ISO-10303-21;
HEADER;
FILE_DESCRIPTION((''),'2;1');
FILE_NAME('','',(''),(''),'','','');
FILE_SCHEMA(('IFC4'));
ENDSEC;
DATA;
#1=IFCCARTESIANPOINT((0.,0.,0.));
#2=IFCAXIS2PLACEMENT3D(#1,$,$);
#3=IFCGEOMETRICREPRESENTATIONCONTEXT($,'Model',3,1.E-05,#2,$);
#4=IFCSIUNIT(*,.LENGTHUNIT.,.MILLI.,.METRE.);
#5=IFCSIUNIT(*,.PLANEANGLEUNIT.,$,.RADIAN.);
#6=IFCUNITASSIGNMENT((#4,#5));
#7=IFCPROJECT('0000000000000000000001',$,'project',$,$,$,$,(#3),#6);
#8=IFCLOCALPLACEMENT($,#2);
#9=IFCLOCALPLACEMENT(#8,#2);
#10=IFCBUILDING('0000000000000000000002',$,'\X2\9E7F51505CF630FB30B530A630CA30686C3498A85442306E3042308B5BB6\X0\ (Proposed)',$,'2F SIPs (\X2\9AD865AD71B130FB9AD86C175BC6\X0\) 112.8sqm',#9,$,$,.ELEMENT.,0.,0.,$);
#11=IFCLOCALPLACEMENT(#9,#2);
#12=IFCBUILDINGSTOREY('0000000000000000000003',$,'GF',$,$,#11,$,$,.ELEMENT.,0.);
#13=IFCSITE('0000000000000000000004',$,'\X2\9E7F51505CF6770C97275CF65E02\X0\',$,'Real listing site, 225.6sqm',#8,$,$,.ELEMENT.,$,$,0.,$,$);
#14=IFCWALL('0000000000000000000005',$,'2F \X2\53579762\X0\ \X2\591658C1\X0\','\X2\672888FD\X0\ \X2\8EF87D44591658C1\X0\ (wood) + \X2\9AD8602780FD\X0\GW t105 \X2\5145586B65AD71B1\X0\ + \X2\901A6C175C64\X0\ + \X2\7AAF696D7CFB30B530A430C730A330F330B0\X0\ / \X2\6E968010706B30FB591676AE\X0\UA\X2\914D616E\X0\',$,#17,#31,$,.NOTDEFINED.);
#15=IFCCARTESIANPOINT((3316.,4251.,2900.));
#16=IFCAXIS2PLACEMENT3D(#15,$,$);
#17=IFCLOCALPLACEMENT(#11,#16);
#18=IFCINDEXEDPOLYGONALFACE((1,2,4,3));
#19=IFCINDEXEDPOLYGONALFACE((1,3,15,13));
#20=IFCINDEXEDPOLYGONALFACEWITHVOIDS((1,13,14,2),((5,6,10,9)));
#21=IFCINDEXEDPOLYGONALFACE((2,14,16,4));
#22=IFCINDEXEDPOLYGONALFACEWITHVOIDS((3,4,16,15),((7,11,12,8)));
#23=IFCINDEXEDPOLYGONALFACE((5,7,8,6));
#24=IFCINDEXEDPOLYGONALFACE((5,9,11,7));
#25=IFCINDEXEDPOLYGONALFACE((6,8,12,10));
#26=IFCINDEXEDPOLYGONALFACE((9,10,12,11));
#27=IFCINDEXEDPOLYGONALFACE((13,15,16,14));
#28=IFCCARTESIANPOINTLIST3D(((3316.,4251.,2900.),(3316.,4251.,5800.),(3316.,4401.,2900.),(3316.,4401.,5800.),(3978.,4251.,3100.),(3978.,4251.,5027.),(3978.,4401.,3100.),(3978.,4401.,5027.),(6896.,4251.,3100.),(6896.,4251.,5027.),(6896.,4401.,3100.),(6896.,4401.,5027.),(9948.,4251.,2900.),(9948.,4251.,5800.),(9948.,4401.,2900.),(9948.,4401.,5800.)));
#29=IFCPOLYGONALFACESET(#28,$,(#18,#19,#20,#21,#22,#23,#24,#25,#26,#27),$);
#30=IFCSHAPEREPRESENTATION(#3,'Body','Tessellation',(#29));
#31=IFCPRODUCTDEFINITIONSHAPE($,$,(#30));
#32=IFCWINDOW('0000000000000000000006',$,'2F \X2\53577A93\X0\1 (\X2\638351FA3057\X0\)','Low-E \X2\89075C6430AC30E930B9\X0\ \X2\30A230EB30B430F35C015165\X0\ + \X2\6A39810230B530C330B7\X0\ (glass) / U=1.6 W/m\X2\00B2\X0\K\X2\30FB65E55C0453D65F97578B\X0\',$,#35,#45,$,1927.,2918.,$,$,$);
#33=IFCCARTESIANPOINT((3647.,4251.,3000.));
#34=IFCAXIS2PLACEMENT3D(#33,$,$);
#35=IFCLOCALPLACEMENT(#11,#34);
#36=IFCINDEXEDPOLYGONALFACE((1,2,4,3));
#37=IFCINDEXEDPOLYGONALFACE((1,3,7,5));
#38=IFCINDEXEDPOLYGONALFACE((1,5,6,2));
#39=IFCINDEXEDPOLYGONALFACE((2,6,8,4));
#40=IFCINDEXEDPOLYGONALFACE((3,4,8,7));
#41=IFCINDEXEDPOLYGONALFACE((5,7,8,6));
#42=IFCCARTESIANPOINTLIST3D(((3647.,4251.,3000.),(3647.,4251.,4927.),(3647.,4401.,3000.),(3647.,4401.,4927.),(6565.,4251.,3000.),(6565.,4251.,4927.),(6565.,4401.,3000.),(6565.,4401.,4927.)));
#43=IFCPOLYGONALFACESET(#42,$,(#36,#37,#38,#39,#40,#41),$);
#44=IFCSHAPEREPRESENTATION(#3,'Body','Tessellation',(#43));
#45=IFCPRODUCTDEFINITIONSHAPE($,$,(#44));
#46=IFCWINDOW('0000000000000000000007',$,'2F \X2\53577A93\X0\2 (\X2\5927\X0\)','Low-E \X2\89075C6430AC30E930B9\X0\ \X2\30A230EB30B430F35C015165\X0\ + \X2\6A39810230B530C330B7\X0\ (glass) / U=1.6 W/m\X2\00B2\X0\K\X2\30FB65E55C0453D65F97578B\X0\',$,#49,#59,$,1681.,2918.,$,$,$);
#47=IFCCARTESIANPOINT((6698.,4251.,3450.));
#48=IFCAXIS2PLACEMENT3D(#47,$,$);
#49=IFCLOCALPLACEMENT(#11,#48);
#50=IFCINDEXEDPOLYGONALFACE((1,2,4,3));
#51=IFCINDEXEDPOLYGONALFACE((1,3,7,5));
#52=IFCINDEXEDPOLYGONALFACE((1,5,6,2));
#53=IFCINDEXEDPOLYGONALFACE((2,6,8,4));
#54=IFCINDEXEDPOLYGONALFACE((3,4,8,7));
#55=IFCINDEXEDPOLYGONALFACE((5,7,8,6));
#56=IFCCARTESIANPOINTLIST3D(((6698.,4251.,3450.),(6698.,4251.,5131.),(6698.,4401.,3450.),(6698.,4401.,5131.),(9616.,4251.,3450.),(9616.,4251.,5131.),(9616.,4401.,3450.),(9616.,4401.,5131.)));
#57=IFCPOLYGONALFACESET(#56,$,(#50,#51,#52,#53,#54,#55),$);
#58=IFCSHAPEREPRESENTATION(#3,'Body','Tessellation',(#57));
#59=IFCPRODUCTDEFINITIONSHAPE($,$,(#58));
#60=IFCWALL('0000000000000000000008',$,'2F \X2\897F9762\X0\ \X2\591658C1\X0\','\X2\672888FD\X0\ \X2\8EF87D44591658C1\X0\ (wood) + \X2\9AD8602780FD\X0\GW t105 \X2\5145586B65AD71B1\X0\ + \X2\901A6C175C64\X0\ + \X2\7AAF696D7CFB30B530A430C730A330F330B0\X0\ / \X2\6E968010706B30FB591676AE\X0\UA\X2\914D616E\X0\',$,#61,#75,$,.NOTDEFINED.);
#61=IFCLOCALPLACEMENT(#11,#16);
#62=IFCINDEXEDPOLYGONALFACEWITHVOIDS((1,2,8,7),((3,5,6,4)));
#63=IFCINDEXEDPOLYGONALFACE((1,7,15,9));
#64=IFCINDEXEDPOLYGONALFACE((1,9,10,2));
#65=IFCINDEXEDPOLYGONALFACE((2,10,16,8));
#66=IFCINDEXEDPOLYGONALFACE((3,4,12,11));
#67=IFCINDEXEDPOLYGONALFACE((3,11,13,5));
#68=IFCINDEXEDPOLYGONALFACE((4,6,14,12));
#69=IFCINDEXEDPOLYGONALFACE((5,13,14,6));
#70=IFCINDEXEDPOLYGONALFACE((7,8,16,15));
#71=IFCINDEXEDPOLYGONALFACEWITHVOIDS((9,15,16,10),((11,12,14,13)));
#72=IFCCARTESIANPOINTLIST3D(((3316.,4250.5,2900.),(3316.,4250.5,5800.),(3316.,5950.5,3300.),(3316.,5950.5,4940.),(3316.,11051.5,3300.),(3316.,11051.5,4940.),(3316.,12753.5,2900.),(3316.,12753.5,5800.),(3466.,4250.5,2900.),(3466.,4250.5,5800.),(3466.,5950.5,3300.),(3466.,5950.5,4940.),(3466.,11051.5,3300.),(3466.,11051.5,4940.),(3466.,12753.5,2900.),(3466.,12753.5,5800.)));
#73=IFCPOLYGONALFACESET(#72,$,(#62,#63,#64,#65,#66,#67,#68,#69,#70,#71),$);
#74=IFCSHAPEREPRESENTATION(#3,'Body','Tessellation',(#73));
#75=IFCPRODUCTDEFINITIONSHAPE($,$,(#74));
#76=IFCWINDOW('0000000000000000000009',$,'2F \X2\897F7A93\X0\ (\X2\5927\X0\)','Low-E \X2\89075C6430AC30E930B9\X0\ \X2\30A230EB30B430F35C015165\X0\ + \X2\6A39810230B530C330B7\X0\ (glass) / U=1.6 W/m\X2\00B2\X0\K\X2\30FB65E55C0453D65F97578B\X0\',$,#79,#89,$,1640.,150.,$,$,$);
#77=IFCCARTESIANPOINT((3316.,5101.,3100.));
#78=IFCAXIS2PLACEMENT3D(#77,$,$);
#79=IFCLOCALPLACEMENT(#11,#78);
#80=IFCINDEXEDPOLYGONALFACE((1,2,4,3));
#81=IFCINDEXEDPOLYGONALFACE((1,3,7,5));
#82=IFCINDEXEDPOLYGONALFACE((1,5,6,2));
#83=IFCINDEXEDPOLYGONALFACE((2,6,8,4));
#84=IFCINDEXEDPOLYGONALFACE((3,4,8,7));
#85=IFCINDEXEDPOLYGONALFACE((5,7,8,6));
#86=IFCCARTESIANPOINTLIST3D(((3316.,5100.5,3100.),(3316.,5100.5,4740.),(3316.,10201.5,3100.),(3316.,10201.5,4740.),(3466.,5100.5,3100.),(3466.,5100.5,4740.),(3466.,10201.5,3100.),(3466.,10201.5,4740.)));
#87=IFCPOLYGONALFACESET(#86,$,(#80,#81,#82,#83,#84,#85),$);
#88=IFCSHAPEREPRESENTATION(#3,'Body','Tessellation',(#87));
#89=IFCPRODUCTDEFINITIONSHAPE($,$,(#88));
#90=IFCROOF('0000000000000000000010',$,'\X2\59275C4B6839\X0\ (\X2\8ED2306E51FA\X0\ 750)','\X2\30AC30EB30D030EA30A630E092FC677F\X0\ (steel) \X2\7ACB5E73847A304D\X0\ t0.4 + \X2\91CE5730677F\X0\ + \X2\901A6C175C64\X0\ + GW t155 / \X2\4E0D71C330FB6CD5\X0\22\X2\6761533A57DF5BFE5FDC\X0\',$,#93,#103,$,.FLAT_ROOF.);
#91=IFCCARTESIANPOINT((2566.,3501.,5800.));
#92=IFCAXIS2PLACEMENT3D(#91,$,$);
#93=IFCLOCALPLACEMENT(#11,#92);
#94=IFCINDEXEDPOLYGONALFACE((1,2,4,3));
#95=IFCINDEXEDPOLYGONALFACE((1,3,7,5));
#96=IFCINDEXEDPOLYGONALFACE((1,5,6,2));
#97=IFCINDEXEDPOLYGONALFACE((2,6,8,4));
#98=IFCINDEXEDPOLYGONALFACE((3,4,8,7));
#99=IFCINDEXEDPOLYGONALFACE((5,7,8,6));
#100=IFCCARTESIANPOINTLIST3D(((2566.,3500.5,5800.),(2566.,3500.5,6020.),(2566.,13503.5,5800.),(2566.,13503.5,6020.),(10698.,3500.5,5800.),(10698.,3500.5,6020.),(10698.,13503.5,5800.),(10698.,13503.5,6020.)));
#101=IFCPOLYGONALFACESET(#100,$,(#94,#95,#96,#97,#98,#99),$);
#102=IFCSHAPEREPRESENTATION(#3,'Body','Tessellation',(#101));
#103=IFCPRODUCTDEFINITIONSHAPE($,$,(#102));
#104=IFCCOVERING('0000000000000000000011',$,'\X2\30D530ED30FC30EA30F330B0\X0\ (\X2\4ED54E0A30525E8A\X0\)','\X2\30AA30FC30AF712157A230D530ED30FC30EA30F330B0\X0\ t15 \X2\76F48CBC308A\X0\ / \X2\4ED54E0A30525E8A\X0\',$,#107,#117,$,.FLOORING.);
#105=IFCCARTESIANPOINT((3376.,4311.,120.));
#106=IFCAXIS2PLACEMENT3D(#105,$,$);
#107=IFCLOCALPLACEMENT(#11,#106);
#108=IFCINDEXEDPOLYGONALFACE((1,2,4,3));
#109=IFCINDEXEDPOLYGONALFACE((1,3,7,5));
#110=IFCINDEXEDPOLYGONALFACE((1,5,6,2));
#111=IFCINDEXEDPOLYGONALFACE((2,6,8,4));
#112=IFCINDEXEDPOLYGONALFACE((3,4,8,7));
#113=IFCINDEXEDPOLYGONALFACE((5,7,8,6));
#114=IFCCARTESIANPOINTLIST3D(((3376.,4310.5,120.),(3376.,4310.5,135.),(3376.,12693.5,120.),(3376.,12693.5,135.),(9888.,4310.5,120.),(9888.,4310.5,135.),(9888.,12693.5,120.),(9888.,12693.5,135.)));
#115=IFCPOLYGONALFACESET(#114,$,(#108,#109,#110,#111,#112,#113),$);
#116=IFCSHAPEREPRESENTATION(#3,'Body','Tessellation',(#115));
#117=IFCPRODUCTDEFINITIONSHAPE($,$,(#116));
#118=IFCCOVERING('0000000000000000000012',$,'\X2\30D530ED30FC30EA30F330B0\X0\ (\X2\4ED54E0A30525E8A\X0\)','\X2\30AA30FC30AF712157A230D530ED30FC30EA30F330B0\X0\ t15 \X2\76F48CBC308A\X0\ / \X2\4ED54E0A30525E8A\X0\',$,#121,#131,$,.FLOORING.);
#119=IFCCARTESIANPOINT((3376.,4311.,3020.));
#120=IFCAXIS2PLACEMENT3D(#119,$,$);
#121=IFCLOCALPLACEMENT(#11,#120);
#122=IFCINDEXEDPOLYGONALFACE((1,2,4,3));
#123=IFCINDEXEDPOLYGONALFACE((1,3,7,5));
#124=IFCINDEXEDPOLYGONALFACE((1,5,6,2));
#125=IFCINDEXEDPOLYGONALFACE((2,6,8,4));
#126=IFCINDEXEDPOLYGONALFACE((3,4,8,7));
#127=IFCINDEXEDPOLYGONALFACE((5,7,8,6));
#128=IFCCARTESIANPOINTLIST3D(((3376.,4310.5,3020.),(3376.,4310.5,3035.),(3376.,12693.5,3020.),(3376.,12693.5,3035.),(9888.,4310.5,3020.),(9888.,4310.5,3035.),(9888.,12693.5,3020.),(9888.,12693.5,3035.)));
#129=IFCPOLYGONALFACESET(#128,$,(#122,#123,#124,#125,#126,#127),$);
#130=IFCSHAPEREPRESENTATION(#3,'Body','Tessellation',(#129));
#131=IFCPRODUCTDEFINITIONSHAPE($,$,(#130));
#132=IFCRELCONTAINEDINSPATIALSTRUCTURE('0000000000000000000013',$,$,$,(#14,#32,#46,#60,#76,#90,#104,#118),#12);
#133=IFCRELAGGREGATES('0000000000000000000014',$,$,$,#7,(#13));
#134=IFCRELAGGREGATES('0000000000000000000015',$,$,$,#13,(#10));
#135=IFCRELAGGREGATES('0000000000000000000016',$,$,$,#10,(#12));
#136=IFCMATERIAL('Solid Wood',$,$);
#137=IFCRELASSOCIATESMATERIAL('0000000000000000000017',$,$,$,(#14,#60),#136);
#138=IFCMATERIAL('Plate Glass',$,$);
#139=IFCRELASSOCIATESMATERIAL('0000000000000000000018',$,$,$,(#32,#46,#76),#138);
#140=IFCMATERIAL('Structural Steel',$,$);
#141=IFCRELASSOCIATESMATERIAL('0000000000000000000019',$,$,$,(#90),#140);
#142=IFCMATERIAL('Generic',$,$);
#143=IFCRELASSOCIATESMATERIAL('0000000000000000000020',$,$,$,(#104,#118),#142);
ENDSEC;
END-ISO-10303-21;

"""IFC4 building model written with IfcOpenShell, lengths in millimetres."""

from ifc_helpers import new_model, si_unit, frame, frame_2d, origin, place, context, project, spatial, rectangle, extrude, material, element, fill, save


model = new_model("IFC4")

# Units and contexts
model_context = context("Model", 3, precision=1e-05, world=origin())
ifc_project = project(units=[si_unit("LENGTHUNIT", "METRE", prefix="MILLI"), si_unit("PLANEANGLEUNIT", "RADIAN")], contexts=[model_context])

# Site, building, storey
site_placement = place(None, origin())
site = spatial("IfcSite", under=ifc_project, at=site_placement, Name="鹿児島県霧島市", ObjectType="Real listing site, 225.6sqm", CompositionType="ELEMENT", RefElevation=0.0)
building_placement = place(site_placement, origin())
building = spatial("IfcBuilding", under=site, at=building_placement, Name="鹿児島・サウナと水風呂のある家 (Proposed)", ObjectType="2F SIPs (高断熱・高気密) 112.8sqm", CompositionType="ELEMENT", ElevationOfRefHeight=0.0, ElevationOfTerrain=0.0)
storey_placement = place(building_placement, origin())
storey = spatial("IfcBuildingStorey", under=building, at=storey_placement, Name="GF", CompositionType="ELEMENT", Elevation=0.0)

# Shared definitions
ifc_material_1 = material(Name="Solid Wood")

# Shared definitions
ifc_material_2 = material(Name="Plate Glass")

# Wall, openings, windows
wall_1_placement = place(storey_placement, frame((3316.0, 4251.0, 2900.0)))
wall_1 = element("IfcWall", 1, at=wall_1_placement, inside=storey, material=ifc_material_1, Name="2F 南面 外壁", Description="木製 軸組外壁 (wood) + 高性能GW t105 充填断熱 + 通気層 + 窯業系サイディング / 準耐火・外皮UA配慮", PredefinedType="NOTDEFINED", context=model_context, shape_type="SweptSolid", body=[
    extrude(rectangle(XDim=6632.0, YDim=150.0, at=frame_2d((3316.0, 75.0))), frame((3316.0, 4251.0, 2900.0)), (0.0, 0.0, 1.0), 2900.0),
])
opening_1_placement = place(storey_placement, frame((3647.0, 4251.0, 3000.0)))
opening_1 = element("IfcOpeningElement", 2, at=opening_1_placement, cuts=wall_1, PredefinedType="NOTDEFINED", context=model_context, shape_type="SweptSolid", body=[
    extrude(rectangle(XDim=2918.0, YDim=150.0, at=frame_2d((1459.0, 75.0))), frame((3647.0, 4251.0, 3000.0)), (0.0, 0.0, 1.0), 1927.0),
])
opening_2_placement = place(storey_placement, frame((6698.0, 4251.0, 3450.0)))
opening_2 = element("IfcOpeningElement", 3, at=opening_2_placement, cuts=wall_1, PredefinedType="NOTDEFINED", context=model_context, shape_type="SweptSolid", body=[
    extrude(rectangle(XDim=2918.0, YDim=150.0, at=frame_2d((1459.0, 75.0))), frame((6698.0, 4251.0, 3450.0)), (0.0, 0.0, 1.0), 1681.0),
])
window_1_placement = place(storey_placement, frame((3647.0, 4251.0, 3000.0)))
window_1 = element("IfcWindow", 4, at=window_1_placement, inside=storey, material=ifc_material_2, Name="2F 南窓1 (掃出し)", Description="Low-E 複層ガラス アルゴン封入 + 樹脂サッシ (glass) / U=1.6 W/m²K・日射取得型", OverallHeight=1927.0, OverallWidth=2918.0, context=model_context, shape_type="SweptSolid", body=[
    extrude(rectangle(XDim=2918.0, YDim=150.0, at=frame_2d((1459.0, 75.0))), frame((3647.0, 4251.0, 3000.0)), (0.0, 0.0, 1.0), 1927.0),
])
fill(opening_1, window_1)
window_2_placement = place(storey_placement, frame((6698.0, 4251.0, 3450.0)))
window_2 = element("IfcWindow", 5, at=window_2_placement, inside=storey, material=ifc_material_2, Name="2F 南窓2 (大)", Description="Low-E 複層ガラス アルゴン封入 + 樹脂サッシ (glass) / U=1.6 W/m²K・日射取得型", OverallHeight=1681.0, OverallWidth=2918.0, context=model_context, shape_type="SweptSolid", body=[
    extrude(rectangle(XDim=2918.0, YDim=150.0, at=frame_2d((1459.0, 75.0))), frame((6698.0, 4251.0, 3450.0)), (0.0, 0.0, 1.0), 1681.0),
])
fill(opening_2, window_2)

# Wall, opening, window
wall_2_placement = place(storey_placement, frame((3316.0, 4251.0, 2900.0)))
wall_2 = element("IfcWall", 6, at=wall_2_placement, inside=storey, material=ifc_material_1, Name="2F 西面 外壁", Description="木製 軸組外壁 (wood) + 高性能GW t105 充填断熱 + 通気層 + 窯業系サイディング / 準耐火・外皮UA配慮", PredefinedType="NOTDEFINED", context=model_context, shape_type="SweptSolid", body=[
    extrude(rectangle(XDim=150.0, YDim=8503.0, at=frame_2d((75.0, 4251.0))), frame((3316.0, 4251.0, 2900.0)), (0.0, 0.0, 1.0), 2900.0),
])
opening_3_placement = place(storey_placement, frame((3316.0, 5101.0, 3100.0)))
opening_3 = element("IfcOpeningElement", 7, at=opening_3_placement, cuts=wall_2, PredefinedType="NOTDEFINED", context=model_context, shape_type="SweptSolid", body=[
    extrude(rectangle(XDim=150.0, YDim=5101.0, at=frame_2d((75.0, 2550.0))), frame((3316.0, 5101.0, 3100.0)), (0.0, 0.0, 1.0), 1640.0),
])
window_3_placement = place(storey_placement, frame((3316.0, 5101.0, 3100.0)))
window_3 = element("IfcWindow", 8, at=window_3_placement, inside=storey, material=ifc_material_2, Name="2F 西窓 (大)", Description="Low-E 複層ガラス アルゴン封入 + 樹脂サッシ (glass) / U=1.6 W/m²K・日射取得型", OverallHeight=1640.0, OverallWidth=150.0, context=model_context, shape_type="SweptSolid", body=[
    extrude(rectangle(XDim=150.0, YDim=5101.0, at=frame_2d((75.0, 2550.0))), frame((3316.0, 5101.0, 3100.0)), (0.0, 0.0, 1.0), 1640.0),
])
fill(opening_3, window_3)

# Roof
ifc_material_3 = material(Name="Structural Steel")
roof_placement = place(storey_placement, frame((2566.0, 3501.0, 5800.0)))
element("IfcRoof", 9, at=roof_placement, inside=storey, material=ifc_material_3, Name="大屋根 (軒の出 750)", Description="ガルバリウム鋼板 (steel) 立平葺き t0.4 + 野地板 + 通気層 + GW t155 / 不燃・法22条区域対応", PredefinedType="FLAT_ROOF", context=model_context, shape_type="SweptSolid", body=[
    extrude(rectangle(XDim=8132.0, YDim=10003.0, at=frame_2d((4066.0, 5001.0))), frame((2566.0, 3501.0, 5800.0)), (0.0, 0.0, 1.0), 220.0),
])

# Coverings
ifc_material_4 = material(Name="Generic")
covering_1_placement = place(storey_placement, frame((3376.0, 4311.0, 120.0)))
element("IfcCovering", 10, at=covering_1_placement, inside=storey, material=ifc_material_4, Name="フローリング (仕上げ床)", Description="オーク無垢フローリング t15 直貼り / 仕上げ床", PredefinedType="FLOORING", context=model_context, shape_type="SweptSolid", body=[
    extrude(rectangle(XDim=6512.0, YDim=8383.0, at=frame_2d((3256.0, 4191.0))), frame((3376.0, 4311.0, 120.0)), (0.0, 0.0, 1.0), 15.0),
])
covering_2_placement = place(storey_placement, frame((3376.0, 4311.0, 3020.0)))
element("IfcCovering", 11, at=covering_2_placement, inside=storey, material=ifc_material_4, Name="フローリング (仕上げ床)", Description="オーク無垢フローリング t15 直貼り / 仕上げ床", PredefinedType="FLOORING", context=model_context, shape_type="SweptSolid", body=[
    extrude(rectangle(XDim=6512.0, YDim=8383.0, at=frame_2d((3256.0, 4191.0))), frame((3376.0, 4311.0, 3020.0)), (0.0, 0.0, 1.0), 15.0),
])

save(model, "model.ifc")
